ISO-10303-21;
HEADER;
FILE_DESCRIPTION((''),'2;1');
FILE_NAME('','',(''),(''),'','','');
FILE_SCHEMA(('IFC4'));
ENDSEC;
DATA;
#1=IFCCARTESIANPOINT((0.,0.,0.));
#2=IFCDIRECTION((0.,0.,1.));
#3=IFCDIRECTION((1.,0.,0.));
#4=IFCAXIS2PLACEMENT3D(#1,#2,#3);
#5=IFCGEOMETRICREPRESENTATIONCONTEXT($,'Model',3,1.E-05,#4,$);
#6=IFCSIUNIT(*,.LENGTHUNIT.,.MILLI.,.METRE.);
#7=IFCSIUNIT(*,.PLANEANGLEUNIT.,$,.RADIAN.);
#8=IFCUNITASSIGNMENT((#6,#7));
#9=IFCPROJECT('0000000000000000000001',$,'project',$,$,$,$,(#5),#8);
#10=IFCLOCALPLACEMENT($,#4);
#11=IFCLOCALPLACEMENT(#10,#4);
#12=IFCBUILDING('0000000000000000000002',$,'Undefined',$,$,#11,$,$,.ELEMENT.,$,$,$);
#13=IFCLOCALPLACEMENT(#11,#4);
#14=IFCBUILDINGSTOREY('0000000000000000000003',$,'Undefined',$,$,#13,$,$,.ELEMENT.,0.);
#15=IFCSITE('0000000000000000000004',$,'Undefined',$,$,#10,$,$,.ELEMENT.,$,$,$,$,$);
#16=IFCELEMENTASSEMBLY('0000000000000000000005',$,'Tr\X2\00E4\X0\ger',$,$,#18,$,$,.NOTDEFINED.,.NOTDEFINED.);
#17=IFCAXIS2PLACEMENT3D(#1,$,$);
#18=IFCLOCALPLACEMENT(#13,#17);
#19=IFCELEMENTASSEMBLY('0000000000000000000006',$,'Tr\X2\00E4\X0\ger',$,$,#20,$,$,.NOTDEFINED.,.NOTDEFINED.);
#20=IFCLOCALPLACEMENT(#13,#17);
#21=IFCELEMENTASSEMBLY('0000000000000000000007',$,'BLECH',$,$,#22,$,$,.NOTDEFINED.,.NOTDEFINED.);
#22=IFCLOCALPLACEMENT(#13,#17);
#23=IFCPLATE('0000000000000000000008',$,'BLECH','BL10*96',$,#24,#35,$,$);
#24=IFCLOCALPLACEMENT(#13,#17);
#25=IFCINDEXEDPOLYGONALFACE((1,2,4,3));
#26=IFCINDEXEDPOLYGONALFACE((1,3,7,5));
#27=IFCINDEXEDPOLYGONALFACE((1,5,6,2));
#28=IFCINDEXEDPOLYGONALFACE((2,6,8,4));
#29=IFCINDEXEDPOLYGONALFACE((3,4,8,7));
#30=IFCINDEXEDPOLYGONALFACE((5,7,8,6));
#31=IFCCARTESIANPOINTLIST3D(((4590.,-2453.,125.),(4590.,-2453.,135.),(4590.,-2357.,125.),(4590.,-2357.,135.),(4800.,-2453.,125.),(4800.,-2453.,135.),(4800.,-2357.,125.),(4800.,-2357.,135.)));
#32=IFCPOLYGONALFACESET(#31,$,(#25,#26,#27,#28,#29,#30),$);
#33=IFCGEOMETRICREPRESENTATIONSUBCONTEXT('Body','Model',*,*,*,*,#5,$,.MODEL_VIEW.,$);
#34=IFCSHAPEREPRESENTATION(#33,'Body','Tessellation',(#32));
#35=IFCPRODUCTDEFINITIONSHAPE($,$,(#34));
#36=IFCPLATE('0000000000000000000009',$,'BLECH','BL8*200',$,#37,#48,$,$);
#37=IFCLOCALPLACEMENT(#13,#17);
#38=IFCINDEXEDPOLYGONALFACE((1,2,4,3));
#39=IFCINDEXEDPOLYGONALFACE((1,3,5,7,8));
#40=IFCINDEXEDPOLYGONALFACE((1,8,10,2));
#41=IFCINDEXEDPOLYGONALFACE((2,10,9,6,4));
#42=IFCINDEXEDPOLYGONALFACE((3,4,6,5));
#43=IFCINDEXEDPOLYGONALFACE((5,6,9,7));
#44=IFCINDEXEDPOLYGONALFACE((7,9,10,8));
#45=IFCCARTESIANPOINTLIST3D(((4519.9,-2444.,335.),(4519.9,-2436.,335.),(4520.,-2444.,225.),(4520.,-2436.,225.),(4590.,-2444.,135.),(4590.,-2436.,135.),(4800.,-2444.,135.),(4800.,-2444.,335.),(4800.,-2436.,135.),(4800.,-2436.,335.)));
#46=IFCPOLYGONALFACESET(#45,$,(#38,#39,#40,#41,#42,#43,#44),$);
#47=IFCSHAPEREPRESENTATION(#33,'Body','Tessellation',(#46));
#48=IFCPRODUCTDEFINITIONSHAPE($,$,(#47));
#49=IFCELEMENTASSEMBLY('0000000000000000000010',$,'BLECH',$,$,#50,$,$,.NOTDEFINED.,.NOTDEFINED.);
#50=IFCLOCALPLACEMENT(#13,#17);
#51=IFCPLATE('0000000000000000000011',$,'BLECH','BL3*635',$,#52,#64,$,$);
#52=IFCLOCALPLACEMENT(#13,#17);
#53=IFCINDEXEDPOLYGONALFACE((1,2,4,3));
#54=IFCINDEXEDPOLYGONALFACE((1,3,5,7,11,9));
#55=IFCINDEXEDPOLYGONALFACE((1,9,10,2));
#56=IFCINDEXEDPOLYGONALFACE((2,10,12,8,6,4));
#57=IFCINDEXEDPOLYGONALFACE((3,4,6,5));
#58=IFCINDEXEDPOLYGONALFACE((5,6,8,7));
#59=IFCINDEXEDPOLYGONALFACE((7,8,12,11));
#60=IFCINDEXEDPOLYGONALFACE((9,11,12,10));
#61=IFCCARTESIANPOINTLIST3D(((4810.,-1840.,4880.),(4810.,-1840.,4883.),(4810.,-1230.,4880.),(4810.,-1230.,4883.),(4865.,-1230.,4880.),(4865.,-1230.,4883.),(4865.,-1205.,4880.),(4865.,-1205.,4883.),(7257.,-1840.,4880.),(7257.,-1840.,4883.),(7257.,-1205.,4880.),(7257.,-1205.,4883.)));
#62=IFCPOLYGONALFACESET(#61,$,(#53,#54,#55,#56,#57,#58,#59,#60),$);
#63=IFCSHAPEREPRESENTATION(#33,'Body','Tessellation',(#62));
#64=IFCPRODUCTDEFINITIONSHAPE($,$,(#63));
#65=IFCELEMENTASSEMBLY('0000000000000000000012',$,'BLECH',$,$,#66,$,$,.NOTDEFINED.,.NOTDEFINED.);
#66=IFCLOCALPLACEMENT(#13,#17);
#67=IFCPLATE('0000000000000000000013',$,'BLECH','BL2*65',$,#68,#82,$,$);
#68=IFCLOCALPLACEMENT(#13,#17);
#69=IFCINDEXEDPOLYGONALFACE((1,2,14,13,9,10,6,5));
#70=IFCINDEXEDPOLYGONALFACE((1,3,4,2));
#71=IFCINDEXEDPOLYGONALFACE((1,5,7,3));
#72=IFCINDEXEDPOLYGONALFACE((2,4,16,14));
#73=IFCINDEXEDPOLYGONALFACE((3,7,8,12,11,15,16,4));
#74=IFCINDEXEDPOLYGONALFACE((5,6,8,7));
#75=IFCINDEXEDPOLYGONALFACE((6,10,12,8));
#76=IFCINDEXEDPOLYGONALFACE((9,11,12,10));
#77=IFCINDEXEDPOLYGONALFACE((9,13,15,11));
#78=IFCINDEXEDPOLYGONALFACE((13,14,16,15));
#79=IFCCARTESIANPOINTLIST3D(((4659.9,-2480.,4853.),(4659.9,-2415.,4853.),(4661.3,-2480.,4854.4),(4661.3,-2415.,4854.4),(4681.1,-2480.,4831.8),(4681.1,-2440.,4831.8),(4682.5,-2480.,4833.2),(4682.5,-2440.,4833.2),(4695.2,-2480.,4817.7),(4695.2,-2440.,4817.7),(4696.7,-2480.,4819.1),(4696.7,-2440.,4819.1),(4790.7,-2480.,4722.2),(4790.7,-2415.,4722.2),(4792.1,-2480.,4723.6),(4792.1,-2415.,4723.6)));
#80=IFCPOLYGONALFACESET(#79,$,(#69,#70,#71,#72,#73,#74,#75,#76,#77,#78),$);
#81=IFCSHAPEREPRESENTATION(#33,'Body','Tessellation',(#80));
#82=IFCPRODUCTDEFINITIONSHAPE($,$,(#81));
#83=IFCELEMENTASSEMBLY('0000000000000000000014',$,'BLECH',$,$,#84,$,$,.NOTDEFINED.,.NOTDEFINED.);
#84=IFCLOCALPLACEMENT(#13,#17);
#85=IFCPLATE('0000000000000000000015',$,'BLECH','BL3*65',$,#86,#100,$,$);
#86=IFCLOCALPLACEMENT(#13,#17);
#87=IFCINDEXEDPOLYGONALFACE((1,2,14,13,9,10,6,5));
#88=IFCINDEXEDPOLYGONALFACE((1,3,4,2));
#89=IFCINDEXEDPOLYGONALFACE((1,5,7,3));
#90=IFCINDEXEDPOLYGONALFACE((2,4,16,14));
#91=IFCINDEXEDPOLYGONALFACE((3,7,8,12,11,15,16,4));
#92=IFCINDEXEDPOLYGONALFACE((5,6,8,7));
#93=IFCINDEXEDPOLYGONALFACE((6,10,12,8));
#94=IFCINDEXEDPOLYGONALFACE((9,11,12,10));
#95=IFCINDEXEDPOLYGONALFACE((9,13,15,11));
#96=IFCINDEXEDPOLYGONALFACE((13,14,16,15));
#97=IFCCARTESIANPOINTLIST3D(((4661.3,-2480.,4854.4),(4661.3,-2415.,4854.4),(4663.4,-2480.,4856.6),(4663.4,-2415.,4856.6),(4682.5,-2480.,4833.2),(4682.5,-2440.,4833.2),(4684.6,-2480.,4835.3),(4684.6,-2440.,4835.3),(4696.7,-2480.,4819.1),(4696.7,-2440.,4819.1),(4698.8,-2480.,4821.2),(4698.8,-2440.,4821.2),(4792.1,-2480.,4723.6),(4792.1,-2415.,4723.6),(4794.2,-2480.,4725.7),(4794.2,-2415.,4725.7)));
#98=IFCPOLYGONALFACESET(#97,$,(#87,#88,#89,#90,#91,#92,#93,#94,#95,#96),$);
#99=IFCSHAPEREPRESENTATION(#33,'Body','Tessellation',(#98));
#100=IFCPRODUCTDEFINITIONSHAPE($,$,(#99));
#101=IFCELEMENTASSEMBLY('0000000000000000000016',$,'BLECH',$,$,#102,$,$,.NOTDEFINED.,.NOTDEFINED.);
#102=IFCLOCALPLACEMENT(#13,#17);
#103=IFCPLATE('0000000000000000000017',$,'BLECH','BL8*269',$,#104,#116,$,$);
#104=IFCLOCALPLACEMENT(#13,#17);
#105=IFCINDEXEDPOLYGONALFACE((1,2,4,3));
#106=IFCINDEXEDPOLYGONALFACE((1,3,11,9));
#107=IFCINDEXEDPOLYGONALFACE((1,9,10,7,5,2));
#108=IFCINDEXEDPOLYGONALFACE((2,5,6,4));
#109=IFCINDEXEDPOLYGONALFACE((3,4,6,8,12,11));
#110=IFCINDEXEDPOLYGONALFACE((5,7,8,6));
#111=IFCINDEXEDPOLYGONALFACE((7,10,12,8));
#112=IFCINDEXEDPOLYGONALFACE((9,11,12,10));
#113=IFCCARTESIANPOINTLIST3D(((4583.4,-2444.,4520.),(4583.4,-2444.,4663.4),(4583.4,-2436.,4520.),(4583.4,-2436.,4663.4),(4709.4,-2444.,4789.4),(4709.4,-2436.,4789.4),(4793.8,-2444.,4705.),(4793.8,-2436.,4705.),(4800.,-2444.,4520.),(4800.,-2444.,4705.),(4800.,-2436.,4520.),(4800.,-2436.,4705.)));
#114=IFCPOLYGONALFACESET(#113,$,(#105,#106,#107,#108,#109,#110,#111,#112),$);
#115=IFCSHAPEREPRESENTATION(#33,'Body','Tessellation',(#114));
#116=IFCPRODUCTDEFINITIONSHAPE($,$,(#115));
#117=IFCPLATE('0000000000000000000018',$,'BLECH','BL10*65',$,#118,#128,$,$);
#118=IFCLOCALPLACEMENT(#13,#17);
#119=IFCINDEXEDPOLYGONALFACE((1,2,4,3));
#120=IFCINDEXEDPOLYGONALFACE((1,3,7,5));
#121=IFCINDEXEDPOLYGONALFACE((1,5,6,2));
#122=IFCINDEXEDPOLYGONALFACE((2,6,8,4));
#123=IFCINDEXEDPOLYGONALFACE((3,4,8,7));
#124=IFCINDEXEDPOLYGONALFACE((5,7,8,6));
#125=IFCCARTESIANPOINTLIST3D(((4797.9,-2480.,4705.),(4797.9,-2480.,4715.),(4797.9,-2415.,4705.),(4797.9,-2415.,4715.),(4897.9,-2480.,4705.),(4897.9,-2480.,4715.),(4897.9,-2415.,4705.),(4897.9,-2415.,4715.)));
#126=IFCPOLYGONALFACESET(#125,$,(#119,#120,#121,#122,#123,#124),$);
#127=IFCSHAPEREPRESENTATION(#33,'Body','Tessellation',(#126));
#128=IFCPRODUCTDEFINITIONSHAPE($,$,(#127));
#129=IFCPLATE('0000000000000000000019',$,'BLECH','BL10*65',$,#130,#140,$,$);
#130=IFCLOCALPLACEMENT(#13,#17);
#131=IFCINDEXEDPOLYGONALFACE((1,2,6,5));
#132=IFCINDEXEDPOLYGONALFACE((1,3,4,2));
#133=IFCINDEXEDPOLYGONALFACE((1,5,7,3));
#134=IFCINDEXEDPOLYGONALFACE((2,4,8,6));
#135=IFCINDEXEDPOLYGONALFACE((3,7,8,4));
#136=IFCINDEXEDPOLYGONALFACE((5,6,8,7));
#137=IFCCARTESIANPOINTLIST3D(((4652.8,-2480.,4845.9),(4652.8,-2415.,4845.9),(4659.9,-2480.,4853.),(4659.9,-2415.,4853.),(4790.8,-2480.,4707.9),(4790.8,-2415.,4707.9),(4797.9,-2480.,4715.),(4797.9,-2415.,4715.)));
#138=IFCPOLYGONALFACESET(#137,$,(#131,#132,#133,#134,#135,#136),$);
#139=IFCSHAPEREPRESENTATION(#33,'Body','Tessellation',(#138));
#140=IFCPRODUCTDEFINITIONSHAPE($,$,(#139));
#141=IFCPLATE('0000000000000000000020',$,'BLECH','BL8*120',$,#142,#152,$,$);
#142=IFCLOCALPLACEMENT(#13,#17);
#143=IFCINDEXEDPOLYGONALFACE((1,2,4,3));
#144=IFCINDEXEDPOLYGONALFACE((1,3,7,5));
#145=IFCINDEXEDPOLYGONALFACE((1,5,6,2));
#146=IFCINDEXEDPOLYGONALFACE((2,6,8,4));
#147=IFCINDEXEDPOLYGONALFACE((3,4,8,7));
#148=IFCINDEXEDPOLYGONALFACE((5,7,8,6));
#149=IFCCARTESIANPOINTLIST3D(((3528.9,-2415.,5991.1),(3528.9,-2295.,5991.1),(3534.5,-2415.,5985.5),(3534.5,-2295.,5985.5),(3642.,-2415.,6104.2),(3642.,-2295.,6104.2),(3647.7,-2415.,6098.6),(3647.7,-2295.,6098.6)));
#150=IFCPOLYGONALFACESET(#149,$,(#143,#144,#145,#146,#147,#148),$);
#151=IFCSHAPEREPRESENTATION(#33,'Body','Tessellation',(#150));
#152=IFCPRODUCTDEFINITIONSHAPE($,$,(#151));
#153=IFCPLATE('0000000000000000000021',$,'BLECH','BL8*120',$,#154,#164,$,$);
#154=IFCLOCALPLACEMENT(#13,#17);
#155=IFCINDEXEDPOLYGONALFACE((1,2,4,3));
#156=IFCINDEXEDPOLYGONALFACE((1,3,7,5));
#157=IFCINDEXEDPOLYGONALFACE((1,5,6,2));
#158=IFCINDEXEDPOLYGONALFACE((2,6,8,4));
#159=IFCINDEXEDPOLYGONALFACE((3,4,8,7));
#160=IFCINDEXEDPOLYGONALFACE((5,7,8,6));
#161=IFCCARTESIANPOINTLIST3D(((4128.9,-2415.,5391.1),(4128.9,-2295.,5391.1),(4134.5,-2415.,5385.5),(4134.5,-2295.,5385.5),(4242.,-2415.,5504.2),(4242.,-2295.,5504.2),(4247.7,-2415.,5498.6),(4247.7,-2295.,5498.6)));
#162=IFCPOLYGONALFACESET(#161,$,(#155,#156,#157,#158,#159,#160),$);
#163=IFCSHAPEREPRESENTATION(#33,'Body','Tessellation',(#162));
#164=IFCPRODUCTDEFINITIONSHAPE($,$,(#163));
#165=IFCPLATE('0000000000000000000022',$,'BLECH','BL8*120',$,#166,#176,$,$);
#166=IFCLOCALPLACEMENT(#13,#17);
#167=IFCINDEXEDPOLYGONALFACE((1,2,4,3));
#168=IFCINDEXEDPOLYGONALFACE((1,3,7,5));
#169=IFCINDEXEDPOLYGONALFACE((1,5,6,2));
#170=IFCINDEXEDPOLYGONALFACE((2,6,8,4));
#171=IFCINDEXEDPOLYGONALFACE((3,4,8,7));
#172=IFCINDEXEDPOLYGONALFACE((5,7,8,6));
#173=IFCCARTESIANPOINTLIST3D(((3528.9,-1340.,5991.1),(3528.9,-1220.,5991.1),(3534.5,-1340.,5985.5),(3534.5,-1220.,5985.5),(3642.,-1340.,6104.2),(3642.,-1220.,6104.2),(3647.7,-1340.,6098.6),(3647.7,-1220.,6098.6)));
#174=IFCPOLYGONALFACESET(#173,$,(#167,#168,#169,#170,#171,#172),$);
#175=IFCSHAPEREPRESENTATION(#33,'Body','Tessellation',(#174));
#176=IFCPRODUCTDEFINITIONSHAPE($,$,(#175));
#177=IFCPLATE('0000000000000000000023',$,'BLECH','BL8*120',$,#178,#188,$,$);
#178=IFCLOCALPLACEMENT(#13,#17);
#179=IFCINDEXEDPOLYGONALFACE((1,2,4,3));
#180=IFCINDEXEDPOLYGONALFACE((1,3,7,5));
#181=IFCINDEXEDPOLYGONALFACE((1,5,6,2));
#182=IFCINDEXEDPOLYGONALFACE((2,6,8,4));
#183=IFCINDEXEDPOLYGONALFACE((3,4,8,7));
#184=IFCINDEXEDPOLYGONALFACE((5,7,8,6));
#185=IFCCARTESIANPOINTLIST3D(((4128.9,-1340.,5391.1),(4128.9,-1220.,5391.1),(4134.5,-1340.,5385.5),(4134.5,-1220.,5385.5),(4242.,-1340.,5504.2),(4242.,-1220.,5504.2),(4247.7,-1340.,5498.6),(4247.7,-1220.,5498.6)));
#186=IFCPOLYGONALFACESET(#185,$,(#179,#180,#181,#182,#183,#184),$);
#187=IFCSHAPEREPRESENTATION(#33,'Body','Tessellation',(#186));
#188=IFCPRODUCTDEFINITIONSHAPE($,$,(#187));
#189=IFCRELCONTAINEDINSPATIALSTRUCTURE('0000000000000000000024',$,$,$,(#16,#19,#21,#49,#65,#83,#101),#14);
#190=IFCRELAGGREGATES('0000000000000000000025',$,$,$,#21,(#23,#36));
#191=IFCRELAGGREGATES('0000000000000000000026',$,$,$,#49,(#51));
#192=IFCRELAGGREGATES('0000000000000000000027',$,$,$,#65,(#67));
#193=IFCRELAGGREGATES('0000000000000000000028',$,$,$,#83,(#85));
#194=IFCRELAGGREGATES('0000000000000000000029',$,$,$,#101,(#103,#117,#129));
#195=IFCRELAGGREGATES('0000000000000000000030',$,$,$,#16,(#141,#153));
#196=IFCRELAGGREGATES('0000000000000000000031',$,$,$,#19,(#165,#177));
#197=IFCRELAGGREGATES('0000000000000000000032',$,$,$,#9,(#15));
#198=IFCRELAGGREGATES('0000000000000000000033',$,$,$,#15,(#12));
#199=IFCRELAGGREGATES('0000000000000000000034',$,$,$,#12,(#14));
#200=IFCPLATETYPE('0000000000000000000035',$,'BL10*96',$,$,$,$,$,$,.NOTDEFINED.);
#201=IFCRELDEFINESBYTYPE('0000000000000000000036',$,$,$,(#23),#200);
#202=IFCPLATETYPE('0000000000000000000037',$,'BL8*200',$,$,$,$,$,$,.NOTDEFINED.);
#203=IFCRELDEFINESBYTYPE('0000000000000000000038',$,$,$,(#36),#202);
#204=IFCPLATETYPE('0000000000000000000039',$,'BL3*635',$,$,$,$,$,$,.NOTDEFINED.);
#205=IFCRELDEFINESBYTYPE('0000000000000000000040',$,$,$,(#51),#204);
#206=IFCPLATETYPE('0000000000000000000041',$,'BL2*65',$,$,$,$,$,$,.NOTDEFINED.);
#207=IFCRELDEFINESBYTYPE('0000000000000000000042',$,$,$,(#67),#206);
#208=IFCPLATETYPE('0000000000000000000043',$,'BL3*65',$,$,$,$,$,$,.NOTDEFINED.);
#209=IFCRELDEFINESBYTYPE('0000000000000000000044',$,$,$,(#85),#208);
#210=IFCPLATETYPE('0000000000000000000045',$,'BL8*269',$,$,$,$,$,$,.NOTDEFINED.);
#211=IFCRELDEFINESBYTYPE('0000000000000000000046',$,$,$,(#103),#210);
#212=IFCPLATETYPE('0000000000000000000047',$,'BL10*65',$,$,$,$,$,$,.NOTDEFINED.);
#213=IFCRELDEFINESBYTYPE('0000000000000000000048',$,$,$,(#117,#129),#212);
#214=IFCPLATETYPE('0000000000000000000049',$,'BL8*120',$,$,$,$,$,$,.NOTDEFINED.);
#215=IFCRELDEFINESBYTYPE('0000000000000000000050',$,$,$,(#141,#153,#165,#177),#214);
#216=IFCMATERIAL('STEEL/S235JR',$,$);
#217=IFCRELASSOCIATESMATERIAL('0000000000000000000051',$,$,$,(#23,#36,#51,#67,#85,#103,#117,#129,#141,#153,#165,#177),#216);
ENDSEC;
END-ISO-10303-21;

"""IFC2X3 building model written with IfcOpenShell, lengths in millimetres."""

from ifc_helpers import new_model, si_unit, frame, origin_with_axes, place, context, subcontext, project, spatial, polyline, outline, extrude, material, type_object, element, aggregate, save


model = new_model("IFC2X3")

# Units and contexts
model_context = context("Model", 3, precision=1e-05, world=origin_with_axes())
body_context = subcontext(model_context, "Body", "Model", "MODEL_VIEW")
ifc_project = project(units=[si_unit("LENGTHUNIT", "METRE", prefix="MILLI"), si_unit("PLANEANGLEUNIT", "RADIAN")], contexts=[model_context])

# Site, building, storey
site_placement = place(None, origin_with_axes())
site = spatial("IfcSite", under=ifc_project, at=site_placement, Name="Undefined", CompositionType="ELEMENT")
building_placement = place(site_placement, origin_with_axes())
building = spatial("IfcBuilding", under=site, at=building_placement, Name="Undefined", CompositionType="ELEMENT")
storey_placement = place(building_placement, origin_with_axes())
storey = spatial("IfcBuildingStorey", under=building, at=storey_placement, Name="Undefined", CompositionType="ELEMENT", Elevation=0.0)

# Shared definitions
ifc_material_1 = material(Name="STEEL/S235JR")

# Element assembly
assembly_1_placement = place(storey_placement, origin_with_axes())
assembly_1 = element("IfcElementAssembly", 1, at=assembly_1_placement, inside=storey, Name="Träger", AssemblyPlace="NOTDEFINED", PredefinedType="NOTDEFINED")

# Element assembly
assembly_2_placement = place(storey_placement, origin_with_axes())
assembly_2 = element("IfcElementAssembly", 2, at=assembly_2_placement, inside=storey, Name="Träger", AssemblyPlace="NOTDEFINED", PredefinedType="NOTDEFINED")

# Element assembly, plates
assembly_3_placement = place(storey_placement, origin_with_axes())
assembly_3 = element("IfcElementAssembly", 3, at=assembly_3_placement, inside=storey, Name="BLECH", AssemblyPlace="NOTDEFINED", PredefinedType="NOTDEFINED")
plate_type_1 = type_object("IfcPlateType", Name="BL10*96", PredefinedType="NOTDEFINED")
plate_1_placement = place(assembly_3_placement, frame((4800.0, -2357.0, 130.0), z_axis=(0.0, 0.0, 1.0), x_axis=(-1.0, 0.0, 0.0)))
plate_1 = element("IfcPlate", 4, at=plate_1_placement, type_object=plate_type_1, material=ifc_material_1, Name="BLECH", Description="BL10*96", context=body_context, shape_type="SweptSolid", body=[
    extrude(outline(polyline([(0.0, 0.0), (210.0, 0.0), (210.0, 96.0), (0.0, 96.0), (0.0, 0.0)])), frame((0.0, 0.0, -5.0), z_axis=(0.0, 0.0, 1.0), x_axis=(1.0, 0.0, 0.0)), (0.0, 0.0, 1.0), 10.0),
])
plate_type_2 = type_object("IfcPlateType", Name="BL8*200", PredefinedType="NOTDEFINED")
plate_2_placement = place(assembly_3_placement, frame((4800.0, -2440.0, 335.0), z_axis=(0.0, 1.0, 0.0), x_axis=(0.0, 0.0, -1.0)))
plate_2 = element("IfcPlate", 5, at=plate_2_placement, type_object=plate_type_2, material=ifc_material_1, Name="BLECH", Description="BL8*200", context=body_context, shape_type="SweptSolid", body=[
    extrude(outline(polyline([(0.0, 0.0), (200.0, 0.0), (200.0, 210.0), (110.0, 280.0), (0.0, 280.1), (0.0, 0.0)])), frame((0.0, 0.0, -4.0), z_axis=(0.0, 0.0, 1.0), x_axis=(1.0, 0.0, 0.0)), (0.0, 0.0, 1.0), 8.0),
])
aggregate(assembly_3, [plate_1, plate_2])

# Element assemblies, plates
assembly_4_placement = place(storey_placement, origin_with_axes())
assembly_4 = element("IfcElementAssembly", 6, at=assembly_4_placement, inside=storey, Name="BLECH", AssemblyPlace="NOTDEFINED", PredefinedType="NOTDEFINED")
plate_type_3 = type_object("IfcPlateType", Name="BL3*635", PredefinedType="NOTDEFINED")
plate_3_placement = place(assembly_4_placement, frame((4865.0, -1230.0, 4881.5), z_axis=(0.0, 0.0, 1.0), x_axis=(-1.0, 0.0, 0.0)))
plate_3 = element("IfcPlate", 7, at=plate_3_placement, type_object=plate_type_3, material=ifc_material_1, Name="BLECH", Description="BL3*635", context=body_context, shape_type="SweptSolid", body=[
    extrude(outline(polyline([(0.0, 0.0), (55.0, 0.0), (55.0, 610.0), (-2392.0, 610.0), (-2392.0, -25.0), (0.0, -25.0), (0.0, 0.0)])), frame((0.0, 0.0, -1.5), z_axis=(0.0, 0.0, 1.0), x_axis=(1.0, 0.0, 0.0)), (0.0, 0.0, 1.0), 3.0),
])
aggregate(assembly_4, [plate_3])
assembly_5_placement = place(storey_placement, origin_with_axes())
assembly_5 = element("IfcElementAssembly", 8, at=assembly_5_placement, inside=storey, Name="BLECH", AssemblyPlace="NOTDEFINED", PredefinedType="NOTDEFINED")
plate_type_4 = type_object("IfcPlateType", Name="BL2*65", PredefinedType="NOTDEFINED")
plate_4_placement = place(assembly_5_placement, frame((4791.4, -2415.0, 4722.9), z_axis=(0.707107, 0.0, 0.707107), x_axis=(-0.707107, 0.0, 0.707107)))
plate_4 = element("IfcPlate", 9, at=plate_4_placement, type_object=plate_type_4, material=ifc_material_1, Name="BLECH", Description="BL2*65", context=body_context, shape_type="SweptSolid", body=[
    extrude(outline(polyline([(0.0, 0.0), (185.0, 0.0), (185.0, 65.0), (155.0, 65.0), (155.0, 25.0), (135.0, 25.0), (135.0, 65.0), (0.0, 65.0), (0.0, 0.0)])), frame((0.0, 0.0, -1.0), z_axis=(0.0, 0.0, 1.0), x_axis=(1.0, 0.0, 0.0)), (0.0, 0.0, 1.0), 2.0),
])
aggregate(assembly_5, [plate_4])
assembly_6_placement = place(storey_placement, origin_with_axes())
assembly_6 = element("IfcElementAssembly", 10, at=assembly_6_placement, inside=storey, Name="BLECH", AssemblyPlace="NOTDEFINED", PredefinedType="NOTDEFINED")
plate_type_5 = type_object("IfcPlateType", Name="BL3*65", PredefinedType="NOTDEFINED")
plate_5_placement = place(assembly_6_placement, frame((4793.2, -2415.0, 4724.7), z_axis=(0.707107, 0.0, 0.707107), x_axis=(-0.707107, 0.0, 0.707107)))
plate_5 = element("IfcPlate", 11, at=plate_5_placement, type_object=plate_type_5, material=ifc_material_1, Name="BLECH", Description="BL3*65", context=body_context, shape_type="SweptSolid", body=[
    extrude(outline(polyline([(0.0, 0.0), (185.0, 0.0), (185.0, 65.0), (155.0, 65.0), (155.0, 25.0), (135.0, 25.0), (135.0, 65.0), (0.0, 65.0), (0.0, 0.0)])), frame((0.0, 0.0, -1.5), z_axis=(0.0, 0.0, 1.0), x_axis=(1.0, 0.0, 0.0)), (0.0, 0.0, 1.0), 3.0),
])
aggregate(assembly_6, [plate_5])

# Element assembly, plates
assembly_7_placement = place(storey_placement, origin_with_axes())
assembly_7 = element("IfcElementAssembly", 12, at=assembly_7_placement, inside=storey, Name="BLECH", AssemblyPlace="NOTDEFINED", PredefinedType="NOTDEFINED")
plate_type_6 = type_object("IfcPlateType", Name="BL8*269", PredefinedType="NOTDEFINED")
plate_6_placement = place(assembly_7_placement, frame((4800.0, -2440.0, 4520.0), z_axis=(0.0, -1.0, 0.0), x_axis=(0.0, 0.0, 1.0)))
plate_6 = element("IfcPlate", 13, at=plate_6_placement, type_object=plate_type_6, material=ifc_material_1, Name="BLECH", Description="BL8*269", context=body_context, shape_type="SweptSolid", body=[
    extrude(outline(polyline([(0.0, 0.0), (185.0, 0.0), (185.0, 6.2), (269.4, 90.6), (143.4, 216.6), (0.0, 216.6), (0.0, 0.0)])), frame((0.0, 0.0, -4.0), z_axis=(0.0, 0.0, 1.0), x_axis=(1.0, 0.0, 0.0)), (0.0, 0.0, 1.0), 8.0),
])
plate_type_7 = type_object("IfcPlateType", Name="BL10*65", PredefinedType="NOTDEFINED")
plate_7_placement = place(assembly_7_placement, frame((4797.9, -2415.0, 4710.0), z_axis=(0.0, 0.0, 1.0), x_axis=(0.0, -1.0, 0.0)))
plate_7 = element("IfcPlate", 14, at=plate_7_placement, type_object=plate_type_7, material=ifc_material_1, Name="BLECH", Description="BL10*65", context=body_context, shape_type="SweptSolid", body=[
    extrude(outline(polyline([(0.0, 0.0), (65.0, 0.0), (65.0, 100.0), (0.0, 100.0), (0.0, 0.0)])), frame((0.0, 0.0, -5.0), z_axis=(0.0, 0.0, 1.0), x_axis=(1.0, 0.0, 0.0)), (0.0, 0.0, 1.0), 10.0),
])
plate_8_placement = place(assembly_7_placement, frame((4656.4, -2415.0, 4849.5), z_axis=(0.707107, 0.0, 0.707107), x_axis=(0.0, -1.0, 0.0)))
plate_8 = element("IfcPlate", 15, at=plate_8_placement, type_object=plate_type_7, material=ifc_material_1, Name="BLECH", Description="BL10*65", context=body_context, shape_type="SweptSolid", body=[
    extrude(outline(polyline([(0.0, 0.0), (65.0, 0.0), (65.0, 195.2), (0.0, 195.2), (0.0, 0.0)])), frame((0.0, 0.0, -5.0), z_axis=(0.0, 0.0, 1.0), x_axis=(1.0, 0.0, 0.0)), (0.0, 0.0, 1.0), 10.0),
])
aggregate(assembly_7, [plate_6, plate_7, plate_8])

# Plates
plate_type_8 = type_object("IfcPlateType", Name="BL8*120", PredefinedType="NOTDEFINED")
plate_9_placement = place(assembly_1_placement, frame((3531.7, -2295.0, 5988.3), z_axis=(-0.707107, 0.0, 0.707107), x_axis=(0.0, -1.0, 0.0)))
plate_9 = element("IfcPlate", 16, at=plate_9_placement, type_object=plate_type_8, material=ifc_material_1, Name="BLECH", Description="BL8*120", context=body_context, shape_type="SweptSolid", body=[
    extrude(outline(polyline([(0.0, 0.0), (120.0, 0.0), (120.0, 160.0), (0.0, 160.0), (0.0, 0.0)])), frame((0.0, 0.0, -4.0), z_axis=(0.0, 0.0, 1.0), x_axis=(1.0, 0.0, 0.0)), (0.0, 0.0, 1.0), 8.0),
])
plate_10_placement = place(assembly_1_placement, frame((4131.7, -2295.0, 5388.3), z_axis=(-0.707107, 0.0, 0.707107), x_axis=(0.0, -1.0, 0.0)))
plate_10 = element("IfcPlate", 17, at=plate_10_placement, type_object=plate_type_8, material=ifc_material_1, Name="BLECH", Description="BL8*120", context=body_context, shape_type="SweptSolid", body=[
    extrude(outline(polyline([(0.0, 0.0), (120.0, 0.0), (120.0, 160.0), (0.0, 160.0), (0.0, 0.0)])), frame((0.0, 0.0, -4.0), z_axis=(0.0, 0.0, 1.0), x_axis=(1.0, 0.0, 0.0)), (0.0, 0.0, 1.0), 8.0),
])
aggregate(assembly_1, [plate_9, plate_10])
plate_11_placement = place(assembly_2_placement, frame((3531.7, -1340.0, 5988.3), z_axis=(0.707107, 0.0, -0.707107), x_axis=(0.0, 1.0, 0.0)))
plate_11 = element("IfcPlate", 18, at=plate_11_placement, type_object=plate_type_8, material=ifc_material_1, Name="BLECH", Description="BL8*120", context=body_context, shape_type="SweptSolid", body=[
    extrude(outline(polyline([(0.0, 0.0), (120.0, 0.0), (120.0, 160.0), (0.0, 160.0), (0.0, 0.0)])), frame((0.0, 0.0, -4.0), z_axis=(0.0, 0.0, 1.0), x_axis=(1.0, 0.0, 0.0)), (0.0, 0.0, 1.0), 8.0),
])
plate_12_placement = place(assembly_2_placement, frame((4131.7, -1340.0, 5388.3), z_axis=(0.707107, 0.0, -0.707107), x_axis=(0.0, 1.0, 0.0)))
plate_12 = element("IfcPlate", 19, at=plate_12_placement, type_object=plate_type_8, material=ifc_material_1, Name="BLECH", Description="BL8*120", context=body_context, shape_type="SweptSolid", body=[
    extrude(outline(polyline([(0.0, 0.0), (120.0, 0.0), (120.0, 160.0), (0.0, 160.0), (0.0, 0.0)])), frame((0.0, 0.0, -4.0), z_axis=(0.0, 0.0, 1.0), x_axis=(1.0, 0.0, 0.0)), (0.0, 0.0, 1.0), 8.0),
])
aggregate(assembly_2, [plate_11, plate_12])

save(model, "model.ifc")
